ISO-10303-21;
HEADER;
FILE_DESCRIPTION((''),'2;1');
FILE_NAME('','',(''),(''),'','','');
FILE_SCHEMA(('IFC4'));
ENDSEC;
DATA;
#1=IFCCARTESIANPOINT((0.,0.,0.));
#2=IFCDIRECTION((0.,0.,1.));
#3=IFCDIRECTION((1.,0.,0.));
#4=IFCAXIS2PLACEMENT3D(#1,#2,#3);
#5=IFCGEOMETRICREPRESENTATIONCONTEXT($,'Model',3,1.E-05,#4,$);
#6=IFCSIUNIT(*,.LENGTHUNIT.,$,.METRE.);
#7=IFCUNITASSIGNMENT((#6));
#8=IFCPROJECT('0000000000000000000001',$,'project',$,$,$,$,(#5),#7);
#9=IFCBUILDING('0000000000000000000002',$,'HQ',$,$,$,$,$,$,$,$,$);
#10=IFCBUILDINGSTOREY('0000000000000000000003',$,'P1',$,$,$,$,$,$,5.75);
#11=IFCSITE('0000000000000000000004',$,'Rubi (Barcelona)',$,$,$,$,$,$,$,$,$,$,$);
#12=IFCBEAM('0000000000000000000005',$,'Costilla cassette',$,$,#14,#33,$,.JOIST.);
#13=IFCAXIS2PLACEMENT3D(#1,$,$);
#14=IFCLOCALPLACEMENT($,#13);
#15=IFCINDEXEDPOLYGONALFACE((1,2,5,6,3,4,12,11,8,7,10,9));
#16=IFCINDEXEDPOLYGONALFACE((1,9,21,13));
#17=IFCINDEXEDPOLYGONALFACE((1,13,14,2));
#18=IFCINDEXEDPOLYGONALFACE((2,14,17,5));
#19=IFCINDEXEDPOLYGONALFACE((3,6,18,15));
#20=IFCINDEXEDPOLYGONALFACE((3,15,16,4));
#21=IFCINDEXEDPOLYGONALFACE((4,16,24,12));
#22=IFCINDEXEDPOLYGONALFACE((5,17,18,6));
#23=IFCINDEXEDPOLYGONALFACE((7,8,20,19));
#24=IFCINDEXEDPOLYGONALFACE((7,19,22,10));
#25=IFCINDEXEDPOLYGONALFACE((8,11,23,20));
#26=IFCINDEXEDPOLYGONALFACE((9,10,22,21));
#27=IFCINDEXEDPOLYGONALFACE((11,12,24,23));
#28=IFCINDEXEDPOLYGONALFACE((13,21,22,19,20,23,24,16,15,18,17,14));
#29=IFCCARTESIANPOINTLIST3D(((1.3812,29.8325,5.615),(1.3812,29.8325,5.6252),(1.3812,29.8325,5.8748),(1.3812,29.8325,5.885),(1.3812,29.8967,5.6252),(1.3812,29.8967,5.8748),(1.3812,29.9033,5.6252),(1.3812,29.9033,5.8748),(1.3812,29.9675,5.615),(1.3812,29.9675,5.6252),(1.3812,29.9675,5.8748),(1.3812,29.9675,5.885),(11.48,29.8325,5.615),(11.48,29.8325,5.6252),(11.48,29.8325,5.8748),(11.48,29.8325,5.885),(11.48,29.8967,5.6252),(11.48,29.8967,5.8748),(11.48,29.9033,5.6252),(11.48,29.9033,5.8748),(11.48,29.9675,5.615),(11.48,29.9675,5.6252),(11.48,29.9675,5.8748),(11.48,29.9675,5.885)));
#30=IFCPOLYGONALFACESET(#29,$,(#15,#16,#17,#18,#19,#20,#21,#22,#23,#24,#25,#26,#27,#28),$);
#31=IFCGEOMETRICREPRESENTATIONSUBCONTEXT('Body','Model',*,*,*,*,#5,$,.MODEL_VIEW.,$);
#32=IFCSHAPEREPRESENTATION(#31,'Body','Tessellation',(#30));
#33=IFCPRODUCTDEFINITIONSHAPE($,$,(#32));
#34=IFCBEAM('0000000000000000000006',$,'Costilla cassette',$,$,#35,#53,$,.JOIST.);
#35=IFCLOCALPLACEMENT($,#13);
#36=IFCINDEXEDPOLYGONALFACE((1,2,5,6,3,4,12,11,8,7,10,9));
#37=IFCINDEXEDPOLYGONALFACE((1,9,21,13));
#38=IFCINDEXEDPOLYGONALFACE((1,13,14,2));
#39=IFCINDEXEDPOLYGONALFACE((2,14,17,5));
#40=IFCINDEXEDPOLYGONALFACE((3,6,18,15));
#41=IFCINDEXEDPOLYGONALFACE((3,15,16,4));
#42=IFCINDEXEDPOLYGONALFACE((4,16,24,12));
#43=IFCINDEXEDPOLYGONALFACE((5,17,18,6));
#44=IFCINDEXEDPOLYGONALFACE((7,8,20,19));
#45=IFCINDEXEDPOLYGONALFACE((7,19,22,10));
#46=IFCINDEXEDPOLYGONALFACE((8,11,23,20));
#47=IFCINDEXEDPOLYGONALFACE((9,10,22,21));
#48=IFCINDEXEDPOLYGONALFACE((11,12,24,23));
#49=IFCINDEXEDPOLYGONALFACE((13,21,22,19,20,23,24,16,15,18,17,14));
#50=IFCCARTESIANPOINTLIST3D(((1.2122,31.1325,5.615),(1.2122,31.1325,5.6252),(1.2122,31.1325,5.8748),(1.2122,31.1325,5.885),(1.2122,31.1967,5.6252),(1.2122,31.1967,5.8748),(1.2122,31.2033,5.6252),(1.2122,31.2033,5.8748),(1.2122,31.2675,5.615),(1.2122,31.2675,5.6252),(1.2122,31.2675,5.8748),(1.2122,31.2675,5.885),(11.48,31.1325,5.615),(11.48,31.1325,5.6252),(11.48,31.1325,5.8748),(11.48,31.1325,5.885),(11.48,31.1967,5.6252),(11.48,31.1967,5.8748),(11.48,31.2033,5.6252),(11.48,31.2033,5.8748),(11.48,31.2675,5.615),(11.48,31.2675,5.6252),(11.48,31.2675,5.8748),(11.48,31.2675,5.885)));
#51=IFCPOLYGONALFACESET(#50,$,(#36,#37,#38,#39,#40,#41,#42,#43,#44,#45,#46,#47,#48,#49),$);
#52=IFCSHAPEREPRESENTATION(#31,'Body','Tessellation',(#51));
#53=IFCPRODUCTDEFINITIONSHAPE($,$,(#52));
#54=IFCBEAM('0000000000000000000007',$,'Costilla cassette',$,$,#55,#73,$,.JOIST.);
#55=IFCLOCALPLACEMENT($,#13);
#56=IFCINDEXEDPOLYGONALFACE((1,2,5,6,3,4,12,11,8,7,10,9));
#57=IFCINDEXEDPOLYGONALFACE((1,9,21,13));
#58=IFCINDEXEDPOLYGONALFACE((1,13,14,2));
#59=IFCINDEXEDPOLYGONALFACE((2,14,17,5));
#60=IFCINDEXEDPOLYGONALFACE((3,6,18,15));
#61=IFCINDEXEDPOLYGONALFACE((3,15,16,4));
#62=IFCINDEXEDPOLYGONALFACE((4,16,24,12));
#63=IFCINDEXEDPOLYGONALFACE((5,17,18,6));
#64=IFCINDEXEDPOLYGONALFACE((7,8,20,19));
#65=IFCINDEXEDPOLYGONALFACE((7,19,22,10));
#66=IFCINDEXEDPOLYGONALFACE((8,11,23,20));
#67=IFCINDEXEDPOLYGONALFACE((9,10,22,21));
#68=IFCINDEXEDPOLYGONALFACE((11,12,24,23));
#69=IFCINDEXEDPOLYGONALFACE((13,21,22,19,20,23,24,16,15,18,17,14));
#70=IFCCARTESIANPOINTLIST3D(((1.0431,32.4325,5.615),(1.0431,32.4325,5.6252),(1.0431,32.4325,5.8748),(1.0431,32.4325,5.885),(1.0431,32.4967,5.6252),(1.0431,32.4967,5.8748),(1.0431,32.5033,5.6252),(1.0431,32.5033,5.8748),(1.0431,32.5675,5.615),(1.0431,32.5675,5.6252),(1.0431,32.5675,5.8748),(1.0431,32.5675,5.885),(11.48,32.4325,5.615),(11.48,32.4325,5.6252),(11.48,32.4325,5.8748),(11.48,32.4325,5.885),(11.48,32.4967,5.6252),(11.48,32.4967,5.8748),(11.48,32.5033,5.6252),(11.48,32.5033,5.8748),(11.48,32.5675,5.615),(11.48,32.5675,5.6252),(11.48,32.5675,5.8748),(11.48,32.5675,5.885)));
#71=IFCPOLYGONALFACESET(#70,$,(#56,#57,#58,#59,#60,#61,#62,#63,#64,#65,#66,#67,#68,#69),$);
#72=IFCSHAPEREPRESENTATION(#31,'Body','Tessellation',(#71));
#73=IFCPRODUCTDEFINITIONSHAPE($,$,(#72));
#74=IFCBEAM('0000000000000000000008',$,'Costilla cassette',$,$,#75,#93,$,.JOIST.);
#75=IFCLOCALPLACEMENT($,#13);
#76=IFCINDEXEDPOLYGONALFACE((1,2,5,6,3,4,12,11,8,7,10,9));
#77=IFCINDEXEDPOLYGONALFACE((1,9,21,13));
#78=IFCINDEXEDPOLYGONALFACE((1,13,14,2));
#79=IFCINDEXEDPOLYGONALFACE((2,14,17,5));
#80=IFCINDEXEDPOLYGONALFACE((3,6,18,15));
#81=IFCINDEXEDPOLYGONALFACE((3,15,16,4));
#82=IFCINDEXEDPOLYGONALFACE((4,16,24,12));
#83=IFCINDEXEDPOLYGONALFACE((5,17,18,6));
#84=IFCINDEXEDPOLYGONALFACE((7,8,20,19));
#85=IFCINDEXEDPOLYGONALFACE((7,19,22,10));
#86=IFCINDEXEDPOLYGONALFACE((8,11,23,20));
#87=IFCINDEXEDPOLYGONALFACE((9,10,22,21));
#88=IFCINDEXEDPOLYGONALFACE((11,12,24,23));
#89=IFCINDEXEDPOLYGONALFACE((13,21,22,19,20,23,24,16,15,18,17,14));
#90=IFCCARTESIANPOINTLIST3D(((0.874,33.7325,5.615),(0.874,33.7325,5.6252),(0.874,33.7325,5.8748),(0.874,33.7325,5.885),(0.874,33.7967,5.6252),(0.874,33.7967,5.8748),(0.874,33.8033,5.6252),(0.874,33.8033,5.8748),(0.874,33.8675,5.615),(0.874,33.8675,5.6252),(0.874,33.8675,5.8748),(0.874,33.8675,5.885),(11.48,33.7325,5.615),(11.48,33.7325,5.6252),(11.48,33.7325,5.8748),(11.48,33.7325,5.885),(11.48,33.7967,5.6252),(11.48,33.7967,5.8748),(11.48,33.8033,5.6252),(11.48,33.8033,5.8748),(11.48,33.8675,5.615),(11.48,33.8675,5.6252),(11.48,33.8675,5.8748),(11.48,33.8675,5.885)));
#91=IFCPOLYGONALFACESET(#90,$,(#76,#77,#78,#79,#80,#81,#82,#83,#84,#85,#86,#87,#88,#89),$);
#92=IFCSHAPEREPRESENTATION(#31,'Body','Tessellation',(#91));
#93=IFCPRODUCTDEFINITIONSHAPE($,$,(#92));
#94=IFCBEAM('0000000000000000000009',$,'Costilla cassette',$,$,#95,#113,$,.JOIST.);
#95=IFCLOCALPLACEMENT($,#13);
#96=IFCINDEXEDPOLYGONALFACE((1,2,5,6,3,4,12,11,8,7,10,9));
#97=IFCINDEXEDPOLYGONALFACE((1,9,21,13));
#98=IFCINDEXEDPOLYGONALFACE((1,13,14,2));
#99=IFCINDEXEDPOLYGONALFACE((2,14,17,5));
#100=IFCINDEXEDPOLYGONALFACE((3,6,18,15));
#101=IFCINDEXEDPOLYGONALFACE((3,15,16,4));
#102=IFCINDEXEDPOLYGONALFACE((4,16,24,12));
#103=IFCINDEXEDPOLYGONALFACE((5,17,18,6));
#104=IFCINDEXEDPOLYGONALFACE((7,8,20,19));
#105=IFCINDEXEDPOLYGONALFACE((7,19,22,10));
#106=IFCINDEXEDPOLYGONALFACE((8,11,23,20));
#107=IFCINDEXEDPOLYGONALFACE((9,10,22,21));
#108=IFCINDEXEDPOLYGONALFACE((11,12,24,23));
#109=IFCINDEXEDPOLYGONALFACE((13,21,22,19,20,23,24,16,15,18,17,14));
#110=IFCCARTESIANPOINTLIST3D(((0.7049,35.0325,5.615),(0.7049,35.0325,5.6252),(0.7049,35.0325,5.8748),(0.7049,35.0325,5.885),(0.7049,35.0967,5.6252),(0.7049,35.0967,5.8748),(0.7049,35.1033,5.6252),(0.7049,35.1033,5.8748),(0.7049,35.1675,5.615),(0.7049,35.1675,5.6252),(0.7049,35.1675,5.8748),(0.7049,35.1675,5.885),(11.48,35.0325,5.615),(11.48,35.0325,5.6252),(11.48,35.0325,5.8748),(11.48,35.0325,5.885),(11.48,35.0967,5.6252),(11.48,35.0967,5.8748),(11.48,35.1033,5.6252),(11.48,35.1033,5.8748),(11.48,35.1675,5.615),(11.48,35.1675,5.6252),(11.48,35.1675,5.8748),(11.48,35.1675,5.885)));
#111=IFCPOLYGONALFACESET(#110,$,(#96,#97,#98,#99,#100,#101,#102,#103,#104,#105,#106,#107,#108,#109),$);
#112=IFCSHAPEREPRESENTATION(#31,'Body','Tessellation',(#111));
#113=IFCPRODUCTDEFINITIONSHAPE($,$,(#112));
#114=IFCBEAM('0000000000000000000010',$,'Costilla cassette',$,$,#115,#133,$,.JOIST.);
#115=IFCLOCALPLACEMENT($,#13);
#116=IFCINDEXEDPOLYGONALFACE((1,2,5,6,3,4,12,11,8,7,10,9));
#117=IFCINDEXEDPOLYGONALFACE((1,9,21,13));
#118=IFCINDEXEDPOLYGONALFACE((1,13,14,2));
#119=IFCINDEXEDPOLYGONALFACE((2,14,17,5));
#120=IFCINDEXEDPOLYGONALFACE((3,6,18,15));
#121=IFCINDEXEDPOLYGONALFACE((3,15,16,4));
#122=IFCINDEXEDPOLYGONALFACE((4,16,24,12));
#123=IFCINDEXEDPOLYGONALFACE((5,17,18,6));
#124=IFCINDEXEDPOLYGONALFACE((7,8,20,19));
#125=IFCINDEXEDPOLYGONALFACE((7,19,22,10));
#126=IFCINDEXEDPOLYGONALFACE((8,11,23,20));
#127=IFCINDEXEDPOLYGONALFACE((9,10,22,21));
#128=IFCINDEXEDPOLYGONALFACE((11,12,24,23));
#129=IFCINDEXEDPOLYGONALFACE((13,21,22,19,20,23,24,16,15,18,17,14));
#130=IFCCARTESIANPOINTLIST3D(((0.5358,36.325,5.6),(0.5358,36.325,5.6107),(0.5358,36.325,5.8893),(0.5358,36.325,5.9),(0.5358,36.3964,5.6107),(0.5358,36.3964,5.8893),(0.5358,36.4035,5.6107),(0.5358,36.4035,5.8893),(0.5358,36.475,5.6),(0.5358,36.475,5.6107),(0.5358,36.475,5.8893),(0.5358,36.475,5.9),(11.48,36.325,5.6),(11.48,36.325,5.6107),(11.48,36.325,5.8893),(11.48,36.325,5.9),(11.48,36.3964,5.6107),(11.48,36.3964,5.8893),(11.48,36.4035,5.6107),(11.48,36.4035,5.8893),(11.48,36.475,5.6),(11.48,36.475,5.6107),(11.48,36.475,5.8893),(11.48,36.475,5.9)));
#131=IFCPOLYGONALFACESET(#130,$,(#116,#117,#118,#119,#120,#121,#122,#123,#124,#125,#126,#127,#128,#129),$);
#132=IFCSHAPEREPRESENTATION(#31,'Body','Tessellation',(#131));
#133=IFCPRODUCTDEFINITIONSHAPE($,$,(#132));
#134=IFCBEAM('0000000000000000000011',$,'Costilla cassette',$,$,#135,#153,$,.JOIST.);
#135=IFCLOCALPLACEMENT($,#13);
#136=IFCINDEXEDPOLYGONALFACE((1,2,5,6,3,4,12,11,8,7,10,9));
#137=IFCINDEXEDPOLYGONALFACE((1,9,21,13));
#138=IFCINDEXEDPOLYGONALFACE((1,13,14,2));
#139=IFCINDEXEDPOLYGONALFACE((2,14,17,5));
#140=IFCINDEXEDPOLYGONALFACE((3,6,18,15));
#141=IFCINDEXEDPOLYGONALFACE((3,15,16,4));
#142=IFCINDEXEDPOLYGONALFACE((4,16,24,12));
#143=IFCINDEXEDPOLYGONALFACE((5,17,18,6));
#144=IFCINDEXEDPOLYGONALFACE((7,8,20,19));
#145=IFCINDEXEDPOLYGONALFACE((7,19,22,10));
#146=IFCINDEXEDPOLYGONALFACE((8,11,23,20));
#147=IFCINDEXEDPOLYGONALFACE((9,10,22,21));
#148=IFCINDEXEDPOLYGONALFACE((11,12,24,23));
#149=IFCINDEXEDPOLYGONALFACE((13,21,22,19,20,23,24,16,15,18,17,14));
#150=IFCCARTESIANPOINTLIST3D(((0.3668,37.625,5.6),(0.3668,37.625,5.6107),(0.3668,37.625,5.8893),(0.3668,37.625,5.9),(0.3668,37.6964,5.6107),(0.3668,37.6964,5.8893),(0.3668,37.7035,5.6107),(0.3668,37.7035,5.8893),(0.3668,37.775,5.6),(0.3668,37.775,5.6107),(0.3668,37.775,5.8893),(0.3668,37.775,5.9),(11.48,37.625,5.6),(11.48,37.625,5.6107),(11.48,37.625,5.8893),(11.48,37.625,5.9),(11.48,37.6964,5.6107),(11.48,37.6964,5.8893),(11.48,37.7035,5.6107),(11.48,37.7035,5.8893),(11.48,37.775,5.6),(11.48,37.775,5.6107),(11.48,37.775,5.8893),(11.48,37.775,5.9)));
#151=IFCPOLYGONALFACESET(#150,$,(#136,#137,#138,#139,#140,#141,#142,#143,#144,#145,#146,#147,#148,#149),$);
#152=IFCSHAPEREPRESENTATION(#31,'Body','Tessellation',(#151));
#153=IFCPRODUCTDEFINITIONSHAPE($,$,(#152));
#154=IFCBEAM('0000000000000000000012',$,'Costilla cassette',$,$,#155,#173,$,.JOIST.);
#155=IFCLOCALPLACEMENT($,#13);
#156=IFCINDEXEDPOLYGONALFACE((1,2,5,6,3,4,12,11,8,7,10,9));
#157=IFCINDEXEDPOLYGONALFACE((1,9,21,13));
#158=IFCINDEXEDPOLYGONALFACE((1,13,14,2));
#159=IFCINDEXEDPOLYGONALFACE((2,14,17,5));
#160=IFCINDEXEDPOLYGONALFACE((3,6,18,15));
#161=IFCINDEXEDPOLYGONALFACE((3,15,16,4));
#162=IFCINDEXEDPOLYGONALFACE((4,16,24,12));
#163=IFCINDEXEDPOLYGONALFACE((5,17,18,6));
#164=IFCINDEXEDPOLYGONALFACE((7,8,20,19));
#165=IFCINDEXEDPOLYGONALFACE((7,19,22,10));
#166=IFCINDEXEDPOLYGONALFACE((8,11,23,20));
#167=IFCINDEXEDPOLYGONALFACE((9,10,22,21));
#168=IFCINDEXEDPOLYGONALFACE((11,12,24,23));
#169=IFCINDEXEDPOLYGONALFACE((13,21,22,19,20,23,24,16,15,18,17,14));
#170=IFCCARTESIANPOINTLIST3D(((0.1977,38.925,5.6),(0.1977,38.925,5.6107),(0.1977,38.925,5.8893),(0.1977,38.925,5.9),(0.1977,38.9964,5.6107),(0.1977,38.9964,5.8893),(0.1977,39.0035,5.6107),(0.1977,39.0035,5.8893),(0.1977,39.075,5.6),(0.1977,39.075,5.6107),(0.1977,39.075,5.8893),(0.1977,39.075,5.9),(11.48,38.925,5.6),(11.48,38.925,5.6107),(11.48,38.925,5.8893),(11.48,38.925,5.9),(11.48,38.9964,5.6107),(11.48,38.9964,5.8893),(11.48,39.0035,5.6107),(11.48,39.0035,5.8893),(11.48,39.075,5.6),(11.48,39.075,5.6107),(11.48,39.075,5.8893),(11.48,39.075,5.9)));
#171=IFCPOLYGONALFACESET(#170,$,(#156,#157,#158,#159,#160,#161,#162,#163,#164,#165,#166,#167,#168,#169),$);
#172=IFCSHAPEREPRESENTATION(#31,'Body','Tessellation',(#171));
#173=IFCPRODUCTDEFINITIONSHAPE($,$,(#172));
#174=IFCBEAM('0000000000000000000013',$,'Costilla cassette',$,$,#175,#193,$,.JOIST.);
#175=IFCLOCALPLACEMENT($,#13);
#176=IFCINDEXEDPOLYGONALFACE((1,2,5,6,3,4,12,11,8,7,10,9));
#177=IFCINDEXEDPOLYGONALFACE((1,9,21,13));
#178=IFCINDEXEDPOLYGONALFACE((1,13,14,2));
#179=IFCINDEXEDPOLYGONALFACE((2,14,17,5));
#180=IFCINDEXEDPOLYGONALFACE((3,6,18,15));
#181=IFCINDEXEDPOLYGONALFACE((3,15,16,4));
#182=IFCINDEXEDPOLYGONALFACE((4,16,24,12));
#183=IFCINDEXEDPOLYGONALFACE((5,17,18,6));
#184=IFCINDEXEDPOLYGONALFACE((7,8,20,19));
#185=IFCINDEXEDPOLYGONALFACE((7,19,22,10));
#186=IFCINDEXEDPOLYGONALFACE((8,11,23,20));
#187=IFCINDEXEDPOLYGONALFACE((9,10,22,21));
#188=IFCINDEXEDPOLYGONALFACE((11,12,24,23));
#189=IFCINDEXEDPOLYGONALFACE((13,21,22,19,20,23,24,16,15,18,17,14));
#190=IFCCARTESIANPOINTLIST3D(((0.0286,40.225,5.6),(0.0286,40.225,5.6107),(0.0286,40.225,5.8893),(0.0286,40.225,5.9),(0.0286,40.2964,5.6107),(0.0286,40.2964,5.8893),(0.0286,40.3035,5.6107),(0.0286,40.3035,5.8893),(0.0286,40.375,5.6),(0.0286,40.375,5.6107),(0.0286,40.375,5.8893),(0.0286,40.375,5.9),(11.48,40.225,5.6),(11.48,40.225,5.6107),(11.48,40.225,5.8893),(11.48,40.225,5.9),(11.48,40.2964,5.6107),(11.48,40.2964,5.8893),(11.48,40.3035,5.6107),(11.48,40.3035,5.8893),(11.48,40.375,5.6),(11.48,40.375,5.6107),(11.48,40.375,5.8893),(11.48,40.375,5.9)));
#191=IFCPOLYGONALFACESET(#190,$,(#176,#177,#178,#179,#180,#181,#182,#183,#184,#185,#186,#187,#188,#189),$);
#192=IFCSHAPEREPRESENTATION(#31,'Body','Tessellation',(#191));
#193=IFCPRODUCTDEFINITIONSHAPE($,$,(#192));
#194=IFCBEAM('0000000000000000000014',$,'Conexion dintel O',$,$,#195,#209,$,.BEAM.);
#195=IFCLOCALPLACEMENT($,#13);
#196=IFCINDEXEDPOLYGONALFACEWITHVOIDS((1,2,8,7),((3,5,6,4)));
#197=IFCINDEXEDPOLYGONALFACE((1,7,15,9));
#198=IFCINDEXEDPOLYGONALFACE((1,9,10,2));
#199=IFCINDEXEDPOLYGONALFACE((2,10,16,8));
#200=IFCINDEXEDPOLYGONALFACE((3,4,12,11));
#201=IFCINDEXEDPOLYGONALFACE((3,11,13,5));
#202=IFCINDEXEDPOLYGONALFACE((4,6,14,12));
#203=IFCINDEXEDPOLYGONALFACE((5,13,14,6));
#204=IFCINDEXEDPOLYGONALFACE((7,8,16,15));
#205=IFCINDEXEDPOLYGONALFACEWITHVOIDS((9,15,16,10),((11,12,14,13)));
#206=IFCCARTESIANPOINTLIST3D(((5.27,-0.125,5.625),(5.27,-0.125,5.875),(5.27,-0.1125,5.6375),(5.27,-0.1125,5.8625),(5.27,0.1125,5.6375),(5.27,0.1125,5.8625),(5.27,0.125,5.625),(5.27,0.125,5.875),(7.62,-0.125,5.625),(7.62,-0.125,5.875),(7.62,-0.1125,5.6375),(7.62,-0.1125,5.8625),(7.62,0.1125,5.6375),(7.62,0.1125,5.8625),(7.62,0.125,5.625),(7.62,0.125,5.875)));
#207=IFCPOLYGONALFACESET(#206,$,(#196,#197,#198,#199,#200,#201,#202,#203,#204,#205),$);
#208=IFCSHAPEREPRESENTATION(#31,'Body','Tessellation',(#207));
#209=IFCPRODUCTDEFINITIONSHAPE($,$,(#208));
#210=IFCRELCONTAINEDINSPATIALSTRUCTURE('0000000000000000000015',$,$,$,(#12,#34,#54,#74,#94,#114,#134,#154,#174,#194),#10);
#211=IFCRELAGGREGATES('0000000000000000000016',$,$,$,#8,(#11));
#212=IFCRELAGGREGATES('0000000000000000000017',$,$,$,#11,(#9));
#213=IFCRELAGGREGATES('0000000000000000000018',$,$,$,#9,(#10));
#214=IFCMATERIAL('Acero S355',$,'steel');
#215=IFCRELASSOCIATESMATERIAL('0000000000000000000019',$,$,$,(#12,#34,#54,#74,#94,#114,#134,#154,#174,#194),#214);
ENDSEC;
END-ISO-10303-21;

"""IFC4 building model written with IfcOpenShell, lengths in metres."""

from ifc_helpers import new_model, si_unit, frame, origin_with_axes, place, context, subcontext, project, spatial, hollow_rectangle, i_section, extrude, material, element, save


model = new_model("IFC4")

# Units and contexts
model_context = context("Model", 3, precision=1e-05, world=origin_with_axes())
body_context = subcontext(model_context, "Body", "Model", "MODEL_VIEW")
ifc_project = project(units=[si_unit("LENGTHUNIT", "METRE")], contexts=[model_context])

# Site, building, storey
site = spatial("IfcSite", under=ifc_project, Name="Rubi (Barcelona)")
building = spatial("IfcBuilding", under=site, Name="HQ")
storey = spatial("IfcBuildingStorey", under=building, Name="P1", Elevation=5.75)

# Beams
ifc_material_1 = material(Name="Acero S355", Category="steel")
beam_1_placement = place(None, origin_with_axes())
element("IfcBeam", 1, at=beam_1_placement, inside=storey, material=ifc_material_1, Name="Costilla cassette", PredefinedType="JOIST", context=body_context, shape_type="SweptSolid", body=[
    extrude(i_section(OverallWidth=0.135, OverallDepth=0.27, WebThickness=0.0066, FlangeThickness=0.0102), frame((1.3812, 29.9, 5.75), z_axis=(1.0, 0.0, 0.0), x_axis=(0.0, 1.0, 0.0)), (0.0, 0.0, 1.0), 10.0988),
])
beam_2_placement = place(None, origin_with_axes())
element("IfcBeam", 2, at=beam_2_placement, inside=storey, material=ifc_material_1, Name="Costilla cassette", PredefinedType="JOIST", context=body_context, shape_type="SweptSolid", body=[
    extrude(i_section(OverallWidth=0.135, OverallDepth=0.27, WebThickness=0.0066, FlangeThickness=0.0102), frame((1.2122, 31.2, 5.75), z_axis=(1.0, 0.0, 0.0), x_axis=(0.0, 1.0, 0.0)), (0.0, 0.0, 1.0), 10.2678),
])
beam_3_placement = place(None, origin_with_axes())
element("IfcBeam", 3, at=beam_3_placement, inside=storey, material=ifc_material_1, Name="Costilla cassette", PredefinedType="JOIST", context=body_context, shape_type="SweptSolid", body=[
    extrude(i_section(OverallWidth=0.135, OverallDepth=0.27, WebThickness=0.0066, FlangeThickness=0.0102), frame((1.0431, 32.5, 5.75), z_axis=(1.0, 0.0, 0.0), x_axis=(0.0, 1.0, 0.0)), (0.0, 0.0, 1.0), 10.4369),
])
beam_4_placement = place(None, origin_with_axes())
element("IfcBeam", 4, at=beam_4_placement, inside=storey, material=ifc_material_1, Name="Costilla cassette", PredefinedType="JOIST", context=body_context, shape_type="SweptSolid", body=[
    extrude(i_section(OverallWidth=0.135, OverallDepth=0.27, WebThickness=0.0066, FlangeThickness=0.0102), frame((0.874, 33.8, 5.75), z_axis=(1.0, 0.0, 0.0), x_axis=(0.0, 1.0, 0.0)), (0.0, 0.0, 1.0), 10.606),
])
beam_5_placement = place(None, origin_with_axes())
element("IfcBeam", 5, at=beam_5_placement, inside=storey, material=ifc_material_1, Name="Costilla cassette", PredefinedType="JOIST", context=body_context, shape_type="SweptSolid", body=[
    extrude(i_section(OverallWidth=0.135, OverallDepth=0.27, WebThickness=0.0066, FlangeThickness=0.0102), frame((0.7049, 35.1, 5.75), z_axis=(1.0, 0.0, 0.0), x_axis=(0.0, 1.0, 0.0)), (0.0, 0.0, 1.0), 10.7751),
])
beam_6_placement = place(None, origin_with_axes())
element("IfcBeam", 6, at=beam_6_placement, inside=storey, material=ifc_material_1, Name="Costilla cassette", PredefinedType="JOIST", context=body_context, shape_type="SweptSolid", body=[
    extrude(i_section(OverallWidth=0.15, OverallDepth=0.3, WebThickness=0.0071, FlangeThickness=0.0107), frame((0.5358, 36.4, 5.75), z_axis=(1.0, 0.0, 0.0), x_axis=(0.0, 1.0, 0.0)), (0.0, 0.0, 1.0), 10.9442),
])
beam_7_placement = place(None, origin_with_axes())
element("IfcBeam", 7, at=beam_7_placement, inside=storey, material=ifc_material_1, Name="Costilla cassette", PredefinedType="JOIST", context=body_context, shape_type="SweptSolid", body=[
    extrude(i_section(OverallWidth=0.15, OverallDepth=0.3, WebThickness=0.0071, FlangeThickness=0.0107), frame((0.3668, 37.7, 5.75), z_axis=(1.0, 0.0, 0.0), x_axis=(0.0, 1.0, 0.0)), (0.0, 0.0, 1.0), 11.1132),
])
beam_8_placement = place(None, origin_with_axes())
element("IfcBeam", 8, at=beam_8_placement, inside=storey, material=ifc_material_1, Name="Costilla cassette", PredefinedType="JOIST", context=body_context, shape_type="SweptSolid", body=[
    extrude(i_section(OverallWidth=0.15, OverallDepth=0.3, WebThickness=0.0071, FlangeThickness=0.0107), frame((0.1977, 39.0, 5.75), z_axis=(1.0, 0.0, 0.0), x_axis=(0.0, 1.0, 0.0)), (0.0, 0.0, 1.0), 11.2823),
])
beam_9_placement = place(None, origin_with_axes())
element("IfcBeam", 9, at=beam_9_placement, inside=storey, material=ifc_material_1, Name="Costilla cassette", PredefinedType="JOIST", context=body_context, shape_type="SweptSolid", body=[
    extrude(i_section(OverallWidth=0.15, OverallDepth=0.3, WebThickness=0.0071, FlangeThickness=0.0107), frame((0.0286, 40.3, 5.75), z_axis=(1.0, 0.0, 0.0), x_axis=(0.0, 1.0, 0.0)), (0.0, 0.0, 1.0), 11.4514),
])
beam_10_placement = place(None, origin_with_axes())
element("IfcBeam", 10, at=beam_10_placement, inside=storey, material=ifc_material_1, Name="Conexion dintel O", PredefinedType="BEAM", context=body_context, shape_type="SweptSolid", body=[
    extrude(hollow_rectangle(XDim=0.25, YDim=0.25, WallThickness=0.0125), frame((5.27, 0.0, 5.75), z_axis=(1.0, 0.0, 0.0), x_axis=(0.0, 1.0, 0.0)), (0.0, 0.0, 1.0), 2.35),
])

save(model, "model.ifc")
